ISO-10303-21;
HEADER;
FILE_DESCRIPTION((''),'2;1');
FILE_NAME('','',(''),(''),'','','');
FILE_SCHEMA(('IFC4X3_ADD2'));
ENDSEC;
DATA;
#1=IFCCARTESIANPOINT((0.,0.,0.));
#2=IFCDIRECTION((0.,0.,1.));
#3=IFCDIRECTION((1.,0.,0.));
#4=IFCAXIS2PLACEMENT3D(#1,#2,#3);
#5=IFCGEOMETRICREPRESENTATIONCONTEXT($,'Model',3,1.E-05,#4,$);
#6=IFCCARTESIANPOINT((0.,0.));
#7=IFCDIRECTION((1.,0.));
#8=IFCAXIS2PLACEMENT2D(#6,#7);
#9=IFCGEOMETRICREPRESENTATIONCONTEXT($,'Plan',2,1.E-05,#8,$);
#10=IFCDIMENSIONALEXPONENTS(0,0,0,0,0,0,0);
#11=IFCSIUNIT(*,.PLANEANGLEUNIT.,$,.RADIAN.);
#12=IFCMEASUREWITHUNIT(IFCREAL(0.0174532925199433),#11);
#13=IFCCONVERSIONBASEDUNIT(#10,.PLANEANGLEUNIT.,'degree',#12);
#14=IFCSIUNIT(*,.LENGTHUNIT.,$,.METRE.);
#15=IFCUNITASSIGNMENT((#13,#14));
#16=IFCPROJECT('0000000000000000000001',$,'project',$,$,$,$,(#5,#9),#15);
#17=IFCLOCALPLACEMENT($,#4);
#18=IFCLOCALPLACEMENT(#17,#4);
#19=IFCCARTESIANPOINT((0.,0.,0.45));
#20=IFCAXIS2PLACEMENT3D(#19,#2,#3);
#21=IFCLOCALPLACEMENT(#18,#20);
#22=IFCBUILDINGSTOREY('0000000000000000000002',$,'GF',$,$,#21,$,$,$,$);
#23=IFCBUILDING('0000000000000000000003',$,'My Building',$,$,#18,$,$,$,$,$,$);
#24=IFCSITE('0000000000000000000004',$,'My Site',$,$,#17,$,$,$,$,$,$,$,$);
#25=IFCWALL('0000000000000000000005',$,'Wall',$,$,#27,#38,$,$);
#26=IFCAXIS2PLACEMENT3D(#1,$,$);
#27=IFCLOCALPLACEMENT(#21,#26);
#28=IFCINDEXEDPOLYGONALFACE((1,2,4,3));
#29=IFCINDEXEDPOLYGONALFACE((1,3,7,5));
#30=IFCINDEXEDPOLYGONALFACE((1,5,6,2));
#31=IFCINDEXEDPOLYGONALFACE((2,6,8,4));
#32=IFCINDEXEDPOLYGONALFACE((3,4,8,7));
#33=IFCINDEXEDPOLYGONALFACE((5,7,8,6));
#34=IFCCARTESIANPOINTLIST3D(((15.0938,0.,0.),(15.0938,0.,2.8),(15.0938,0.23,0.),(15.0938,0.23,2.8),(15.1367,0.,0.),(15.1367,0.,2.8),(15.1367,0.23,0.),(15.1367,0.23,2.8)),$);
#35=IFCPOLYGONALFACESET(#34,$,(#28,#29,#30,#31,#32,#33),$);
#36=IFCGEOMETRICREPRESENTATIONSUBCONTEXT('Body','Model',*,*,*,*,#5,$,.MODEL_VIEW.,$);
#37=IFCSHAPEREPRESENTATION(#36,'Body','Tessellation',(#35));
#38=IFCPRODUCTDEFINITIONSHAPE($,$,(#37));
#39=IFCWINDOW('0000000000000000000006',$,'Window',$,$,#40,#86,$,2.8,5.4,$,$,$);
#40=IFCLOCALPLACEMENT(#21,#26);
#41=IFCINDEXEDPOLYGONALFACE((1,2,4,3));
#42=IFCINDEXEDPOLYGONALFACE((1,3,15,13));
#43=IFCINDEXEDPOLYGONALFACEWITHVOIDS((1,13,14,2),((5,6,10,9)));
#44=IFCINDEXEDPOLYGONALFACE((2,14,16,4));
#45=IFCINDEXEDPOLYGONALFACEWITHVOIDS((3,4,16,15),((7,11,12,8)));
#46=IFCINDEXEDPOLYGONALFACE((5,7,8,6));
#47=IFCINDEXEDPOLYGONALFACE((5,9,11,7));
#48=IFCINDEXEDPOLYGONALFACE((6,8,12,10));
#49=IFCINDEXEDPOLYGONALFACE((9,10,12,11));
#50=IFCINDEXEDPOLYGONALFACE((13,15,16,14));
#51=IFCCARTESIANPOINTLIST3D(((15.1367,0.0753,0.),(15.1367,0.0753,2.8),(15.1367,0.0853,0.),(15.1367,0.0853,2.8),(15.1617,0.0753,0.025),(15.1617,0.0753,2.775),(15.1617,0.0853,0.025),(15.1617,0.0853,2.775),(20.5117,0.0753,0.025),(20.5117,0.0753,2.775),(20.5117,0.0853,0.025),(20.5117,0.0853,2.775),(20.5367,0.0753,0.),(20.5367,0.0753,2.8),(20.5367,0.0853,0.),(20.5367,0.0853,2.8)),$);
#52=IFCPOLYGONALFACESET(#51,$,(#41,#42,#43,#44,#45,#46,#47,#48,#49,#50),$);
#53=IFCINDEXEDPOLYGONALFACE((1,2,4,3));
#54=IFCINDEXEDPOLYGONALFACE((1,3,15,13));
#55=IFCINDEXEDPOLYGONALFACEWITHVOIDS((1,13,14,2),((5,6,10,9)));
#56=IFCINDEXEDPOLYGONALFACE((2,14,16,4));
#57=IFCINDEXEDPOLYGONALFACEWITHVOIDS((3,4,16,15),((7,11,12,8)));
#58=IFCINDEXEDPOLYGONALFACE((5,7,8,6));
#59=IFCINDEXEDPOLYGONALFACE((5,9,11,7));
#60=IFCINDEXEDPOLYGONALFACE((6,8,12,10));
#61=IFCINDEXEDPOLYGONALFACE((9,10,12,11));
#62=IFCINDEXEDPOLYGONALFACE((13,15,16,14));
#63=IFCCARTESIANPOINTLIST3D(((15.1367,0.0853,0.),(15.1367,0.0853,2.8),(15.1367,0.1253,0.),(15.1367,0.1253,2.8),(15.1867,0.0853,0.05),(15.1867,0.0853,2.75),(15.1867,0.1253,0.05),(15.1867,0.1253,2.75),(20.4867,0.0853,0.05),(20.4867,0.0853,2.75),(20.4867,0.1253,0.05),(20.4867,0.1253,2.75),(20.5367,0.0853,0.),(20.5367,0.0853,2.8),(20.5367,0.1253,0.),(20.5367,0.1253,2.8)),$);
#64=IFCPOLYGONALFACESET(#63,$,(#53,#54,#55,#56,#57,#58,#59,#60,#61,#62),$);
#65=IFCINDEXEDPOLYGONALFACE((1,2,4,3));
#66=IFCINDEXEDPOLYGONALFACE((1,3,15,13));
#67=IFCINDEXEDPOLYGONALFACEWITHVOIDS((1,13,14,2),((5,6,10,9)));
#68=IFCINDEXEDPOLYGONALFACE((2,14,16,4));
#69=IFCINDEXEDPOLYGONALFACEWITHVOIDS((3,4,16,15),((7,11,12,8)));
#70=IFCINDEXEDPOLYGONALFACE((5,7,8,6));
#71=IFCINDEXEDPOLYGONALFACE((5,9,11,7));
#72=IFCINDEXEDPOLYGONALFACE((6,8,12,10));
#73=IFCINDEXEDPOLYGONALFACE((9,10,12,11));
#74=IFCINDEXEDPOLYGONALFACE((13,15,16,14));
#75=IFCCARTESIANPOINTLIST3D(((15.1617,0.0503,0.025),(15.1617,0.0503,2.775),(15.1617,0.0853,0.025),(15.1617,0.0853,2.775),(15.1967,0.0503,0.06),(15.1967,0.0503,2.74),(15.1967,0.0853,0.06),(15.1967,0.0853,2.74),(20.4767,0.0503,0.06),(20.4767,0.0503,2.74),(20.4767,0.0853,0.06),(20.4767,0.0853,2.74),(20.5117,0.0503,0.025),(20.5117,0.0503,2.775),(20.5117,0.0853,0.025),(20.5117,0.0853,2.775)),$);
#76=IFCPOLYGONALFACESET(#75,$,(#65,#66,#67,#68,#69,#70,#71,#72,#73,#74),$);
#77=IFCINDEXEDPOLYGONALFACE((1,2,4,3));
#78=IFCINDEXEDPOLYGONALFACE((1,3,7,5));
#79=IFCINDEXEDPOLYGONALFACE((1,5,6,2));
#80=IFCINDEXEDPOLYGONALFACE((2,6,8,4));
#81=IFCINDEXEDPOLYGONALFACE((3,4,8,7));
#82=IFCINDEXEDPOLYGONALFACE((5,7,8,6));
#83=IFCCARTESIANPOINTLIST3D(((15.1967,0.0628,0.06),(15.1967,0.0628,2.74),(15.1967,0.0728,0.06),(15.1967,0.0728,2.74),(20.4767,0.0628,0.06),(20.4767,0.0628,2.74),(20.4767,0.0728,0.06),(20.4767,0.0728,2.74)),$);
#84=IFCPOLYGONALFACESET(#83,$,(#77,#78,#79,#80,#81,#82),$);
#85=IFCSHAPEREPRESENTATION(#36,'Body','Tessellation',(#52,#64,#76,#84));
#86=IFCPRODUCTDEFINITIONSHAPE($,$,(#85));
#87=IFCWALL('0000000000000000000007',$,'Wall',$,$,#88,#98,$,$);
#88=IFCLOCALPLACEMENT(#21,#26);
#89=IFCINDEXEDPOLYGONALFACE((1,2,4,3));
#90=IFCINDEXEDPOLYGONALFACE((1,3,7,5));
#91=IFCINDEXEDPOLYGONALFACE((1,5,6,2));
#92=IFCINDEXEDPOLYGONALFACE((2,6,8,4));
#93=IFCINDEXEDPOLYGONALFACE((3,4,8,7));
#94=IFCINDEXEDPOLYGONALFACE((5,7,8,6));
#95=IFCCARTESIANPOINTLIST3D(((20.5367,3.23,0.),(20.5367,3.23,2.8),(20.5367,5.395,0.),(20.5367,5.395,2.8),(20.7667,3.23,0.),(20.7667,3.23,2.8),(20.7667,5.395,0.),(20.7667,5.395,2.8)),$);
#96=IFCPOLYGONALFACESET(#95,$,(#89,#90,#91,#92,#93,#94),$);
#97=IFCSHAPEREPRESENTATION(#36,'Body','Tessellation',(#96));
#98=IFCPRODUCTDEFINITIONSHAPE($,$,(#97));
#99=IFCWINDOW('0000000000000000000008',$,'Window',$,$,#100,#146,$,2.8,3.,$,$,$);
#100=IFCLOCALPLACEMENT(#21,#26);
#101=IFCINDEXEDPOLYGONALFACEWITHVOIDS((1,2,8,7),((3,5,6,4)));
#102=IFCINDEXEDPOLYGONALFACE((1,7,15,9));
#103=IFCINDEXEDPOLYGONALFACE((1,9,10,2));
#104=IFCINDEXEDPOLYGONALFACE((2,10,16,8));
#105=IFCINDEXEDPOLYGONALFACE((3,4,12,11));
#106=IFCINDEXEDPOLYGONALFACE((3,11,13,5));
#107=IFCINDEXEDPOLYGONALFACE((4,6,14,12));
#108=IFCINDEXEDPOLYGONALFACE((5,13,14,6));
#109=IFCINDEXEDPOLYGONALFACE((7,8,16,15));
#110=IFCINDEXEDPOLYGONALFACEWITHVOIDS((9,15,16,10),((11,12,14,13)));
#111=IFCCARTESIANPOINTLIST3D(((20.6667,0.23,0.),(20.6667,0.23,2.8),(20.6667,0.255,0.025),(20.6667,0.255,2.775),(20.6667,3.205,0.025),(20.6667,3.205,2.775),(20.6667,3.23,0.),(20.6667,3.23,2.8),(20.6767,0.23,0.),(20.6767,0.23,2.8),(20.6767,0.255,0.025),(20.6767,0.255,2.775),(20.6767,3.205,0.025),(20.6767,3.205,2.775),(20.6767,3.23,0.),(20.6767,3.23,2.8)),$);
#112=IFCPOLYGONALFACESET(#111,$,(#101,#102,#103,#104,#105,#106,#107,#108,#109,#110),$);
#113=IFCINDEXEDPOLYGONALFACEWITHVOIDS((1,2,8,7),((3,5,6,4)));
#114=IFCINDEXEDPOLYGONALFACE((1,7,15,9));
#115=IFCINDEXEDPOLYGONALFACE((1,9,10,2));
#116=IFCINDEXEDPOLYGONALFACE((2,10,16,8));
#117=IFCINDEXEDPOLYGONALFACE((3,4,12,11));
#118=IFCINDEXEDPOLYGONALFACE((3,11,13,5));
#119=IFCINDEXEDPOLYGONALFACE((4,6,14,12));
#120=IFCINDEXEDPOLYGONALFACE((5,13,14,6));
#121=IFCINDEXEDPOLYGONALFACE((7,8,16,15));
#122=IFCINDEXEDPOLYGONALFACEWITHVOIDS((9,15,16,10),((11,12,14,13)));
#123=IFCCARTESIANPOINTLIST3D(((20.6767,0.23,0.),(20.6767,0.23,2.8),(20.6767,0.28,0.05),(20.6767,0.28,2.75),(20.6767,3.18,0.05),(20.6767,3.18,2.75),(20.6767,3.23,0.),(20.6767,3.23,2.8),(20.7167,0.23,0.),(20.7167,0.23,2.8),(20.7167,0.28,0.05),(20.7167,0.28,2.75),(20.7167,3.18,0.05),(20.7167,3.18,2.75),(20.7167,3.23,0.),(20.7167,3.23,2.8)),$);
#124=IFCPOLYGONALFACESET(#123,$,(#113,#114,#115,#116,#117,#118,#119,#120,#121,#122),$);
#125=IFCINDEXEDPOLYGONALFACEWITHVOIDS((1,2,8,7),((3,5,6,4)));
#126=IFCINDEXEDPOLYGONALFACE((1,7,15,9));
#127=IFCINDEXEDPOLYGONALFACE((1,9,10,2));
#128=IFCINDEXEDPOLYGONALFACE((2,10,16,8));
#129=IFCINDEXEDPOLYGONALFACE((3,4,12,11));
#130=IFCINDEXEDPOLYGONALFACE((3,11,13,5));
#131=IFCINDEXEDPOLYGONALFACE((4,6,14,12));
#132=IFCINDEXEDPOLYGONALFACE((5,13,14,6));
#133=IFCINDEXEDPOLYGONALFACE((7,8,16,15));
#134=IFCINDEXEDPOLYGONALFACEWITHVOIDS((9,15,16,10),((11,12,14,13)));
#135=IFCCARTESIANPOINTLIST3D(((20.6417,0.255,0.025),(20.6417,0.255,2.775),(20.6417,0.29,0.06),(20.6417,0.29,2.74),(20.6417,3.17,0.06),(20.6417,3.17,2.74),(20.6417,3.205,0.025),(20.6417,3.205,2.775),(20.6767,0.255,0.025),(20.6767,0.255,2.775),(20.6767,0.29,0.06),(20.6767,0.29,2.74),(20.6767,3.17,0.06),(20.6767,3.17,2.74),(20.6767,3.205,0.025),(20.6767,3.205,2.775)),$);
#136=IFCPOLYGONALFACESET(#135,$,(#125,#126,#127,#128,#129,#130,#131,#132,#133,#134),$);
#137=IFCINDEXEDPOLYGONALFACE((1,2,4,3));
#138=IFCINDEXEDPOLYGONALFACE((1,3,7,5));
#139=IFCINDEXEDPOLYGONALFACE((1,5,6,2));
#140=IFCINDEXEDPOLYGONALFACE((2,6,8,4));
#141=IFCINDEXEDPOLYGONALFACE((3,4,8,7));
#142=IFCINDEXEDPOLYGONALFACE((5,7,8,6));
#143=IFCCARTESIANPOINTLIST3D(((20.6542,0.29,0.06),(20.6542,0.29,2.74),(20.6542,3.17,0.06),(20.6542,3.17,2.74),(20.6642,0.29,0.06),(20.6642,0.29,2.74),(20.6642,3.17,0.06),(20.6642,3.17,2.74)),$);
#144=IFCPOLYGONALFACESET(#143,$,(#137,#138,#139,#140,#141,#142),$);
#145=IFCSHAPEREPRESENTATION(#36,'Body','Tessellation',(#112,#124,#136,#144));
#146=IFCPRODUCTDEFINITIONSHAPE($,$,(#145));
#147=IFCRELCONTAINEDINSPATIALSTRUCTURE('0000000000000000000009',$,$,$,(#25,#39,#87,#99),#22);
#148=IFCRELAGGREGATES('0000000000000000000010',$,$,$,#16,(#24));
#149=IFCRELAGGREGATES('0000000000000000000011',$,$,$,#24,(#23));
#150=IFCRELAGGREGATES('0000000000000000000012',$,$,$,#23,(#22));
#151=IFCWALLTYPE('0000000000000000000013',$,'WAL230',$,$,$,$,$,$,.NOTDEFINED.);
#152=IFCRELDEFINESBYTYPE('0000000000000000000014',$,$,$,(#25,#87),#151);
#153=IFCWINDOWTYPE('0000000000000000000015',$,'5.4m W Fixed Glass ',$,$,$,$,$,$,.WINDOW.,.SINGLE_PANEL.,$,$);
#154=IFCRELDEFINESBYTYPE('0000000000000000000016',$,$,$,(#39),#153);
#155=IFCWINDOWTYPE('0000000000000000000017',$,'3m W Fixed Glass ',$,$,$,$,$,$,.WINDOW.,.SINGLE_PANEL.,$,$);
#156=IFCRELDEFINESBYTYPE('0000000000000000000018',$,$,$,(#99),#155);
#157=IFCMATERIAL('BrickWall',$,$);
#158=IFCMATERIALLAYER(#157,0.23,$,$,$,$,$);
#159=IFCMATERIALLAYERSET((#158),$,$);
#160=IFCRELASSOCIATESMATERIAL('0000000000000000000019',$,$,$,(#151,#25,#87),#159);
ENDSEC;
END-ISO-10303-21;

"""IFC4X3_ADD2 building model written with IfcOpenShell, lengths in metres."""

from ifc_helpers import new_model, entity, si_unit, converted_unit, frame, origin_with_axes, origin_2d_with_axis, place, context, subcontext, project, spatial, line, indexed_curve, outline, extrude, shape, source, transform, mapped, material, layer, layer_set, layer_usage, type_object, type_shapes, element, fill, save


model = new_model("IFC4X3_ADD2")

# Units and contexts
model_context = context("Model", 3, precision=1e-05, world=origin_with_axes())
plan_context = context("Plan", 2, precision=1e-05, world=origin_2d_with_axis())
body_context_1 = subcontext(model_context, "Body", "Model", "MODEL_VIEW")
body_context_2 = subcontext(plan_context, "Body", "Plan", "PLAN_VIEW")
ifc_project = project(units=[converted_unit("PLANEANGLEUNIT", "degree", entity("IfcReal", 0.0174532925199433), si_unit("PLANEANGLEUNIT", "RADIAN"), dimensions=[0, 0, 0, 0, 0, 0, 0]), si_unit("LENGTHUNIT", "METRE")], contexts=[model_context, plan_context])

# Site, building, storey
site_placement = place(None, origin_with_axes())
site = spatial("IfcSite", under=ifc_project, at=site_placement, Name="My Site")
building_placement = place(site_placement, origin_with_axes())
building = spatial("IfcBuilding", under=site, at=building_placement, Name="My Building")
storey_placement = place(building_placement, frame((0.0, 0.0, 0.45), z_axis=(0.0, 0.0, 1.0), x_axis=(1.0, 0.0, 0.0)))
storey = spatial("IfcBuildingStorey", under=building, at=storey_placement, Name="GF")

# Walls, openings, windows
ifc_material = material(Name="BrickWall")
ifc_layer_1 = layer(ifc_material, 0.23)
ifc_layer_set_1 = layer_set([ifc_layer_1])
ifc_layer_usage_1 = layer_usage(ifc_layer_set_1, "AXIS2", "POSITIVE", 0.0)
wall_type_1 = type_object("IfcWallType", Name="WAL230", PredefinedType="NOTDEFINED", material=ifc_layer_set_1)
wall_1_placement = place(storey_placement, frame((15.1367, 0.23, 0.0), z_axis=(0.0, 0.0, 1.0), x_axis=(-1.0, 0.0, 0.0)))
wall_1 = element("IfcWall", 1, at=wall_1_placement, inside=storey, type_object=wall_type_1, material=ifc_layer_usage_1, Name="Wall", context=body_context_1, shape_type="SweptSolid", body=[
    extrude(outline(indexed_curve([(0.0, 0.0), (0.0, 0.23), (0.0429, 0.23), (0.0429, 0.0), (0.0, 0.0)], self_intersect=False)), origin_with_axes(), (0.0, 0.0, 1.0), 2.8),
])
shared_shape_1 = source(origin_with_axes(), body_context_1, "Body", "SweptSolid", [
    extrude(outline(indexed_curve([(0.0, 0.0), (5.4, 0.0), (5.4, 2.8), (0.0, 2.8)], segments=[line(1, 2, 3, 4, 1)])), frame((0.0, -0.6, 0.0), z_axis=(0.0, -1.0, 0.0), x_axis=(1.0, 0.0, 0.0)), (0.0, 0.0, -1.0), 1.2),
])
opening_1_placement = place(wall_1_placement, frame((-5.4, 0.0, 0.0), z_axis=(0.0, 0.0, 1.0), x_axis=(1.0, 0.0, 0.0)))
opening_1 = element("IfcOpeningElement", 2, at=opening_1_placement, cuts=wall_1, PredefinedType="OPENING", context=body_context_1, shape_type="MappedRepresentation", body=[
    mapped(shared_shape_1, transform((0.0, 0.0, 0.0), x_axis=(1.0, 0.0, 0.0), y_axis=(0.0, 1.0, 0.0), z_axis=(0.0, 0.0, 1.0), scale=1.0)),
])
window_type_1 = type_object("IfcWindowType", Name="5.4m W Fixed Glass ", PartitioningType="SINGLE_PANEL", PredefinedType="WINDOW")
shared_shape_2 = source(origin_with_axes(), body_context_1, "Body", "SweptSolid", [
    extrude(outline(indexed_curve([(0.0, 0.0), (5.4, 0.0), (5.4, 2.8), (0.0, 2.8)], segments=[line(1, 2, 3, 4, 1)]), holes=[indexed_curve([(0.025, 0.025), (5.375, 0.025), (5.375, 2.775), (0.025, 2.775)], segments=[line(1, 2, 3, 4, 1)])]), frame((0.0, 0.09, 0.0), z_axis=(0.0, -1.0, 0.0), x_axis=(1.0, 0.0, 0.0)), (0.0, 0.0, -1.0), 0.01),
    extrude(outline(indexed_curve([(0.0, 0.0), (5.4, 0.0), (5.4, 2.8), (0.0, 2.8)], segments=[line(1, 2, 3, 4, 1)]), holes=[indexed_curve([(0.05, 0.05), (5.35, 0.05), (5.35, 2.75), (0.05, 2.75)], segments=[line(1, 2, 3, 4, 1)])]), frame((0.0, 0.05, 0.0), z_axis=(0.0, -1.0, 0.0), x_axis=(1.0, 0.0, 0.0)), (0.0, 0.0, -1.0), 0.04),
    extrude(outline(indexed_curve([(0.0, 0.0), (5.35, 0.0), (5.35, 2.75), (0.0, 2.75)], segments=[line(1, 2, 3, 4, 1)]), holes=[indexed_curve([(0.035, 0.035), (5.315, 0.035), (5.315, 2.715), (0.035, 2.715)], segments=[line(1, 2, 3, 4, 1)])]), frame((0.025, 0.09, 0.025), z_axis=(0.0, -1.0, 0.0), x_axis=(1.0, 0.0, 0.0)), (0.0, 0.0, -1.0), 0.035),
    extrude(outline(indexed_curve([(0.035, 0.035), (5.315, 0.035), (5.315, 2.715), (0.035, 2.715)], segments=[line(1, 2, 3, 4, 1)])), frame((0.025, 0.1025, 0.025), z_axis=(0.0, -1.0, 0.0), x_axis=(1.0, 0.0, 0.0)), (0.0, 0.0, -1.0), 0.01),
])
shared_shape_3 = source(origin_with_axes(), body_context_2, "Body", "Curve2D", [
    entity("IfcIndexedPolyCurve", entity("IfcCartesianPointList2D", [[0.05, 0.05], [5.35, 0.05]])),
    entity("IfcIndexedPolyCurve", entity("IfcCartesianPointList2D", [[0.0, 0.1], [0.025, 0.1], [0.025, 0.09], [0.05, 0.09], [0.05, 0.05], [0.0, 0.05]]), [entity("IfcLineIndex", [1, 2, 3, 4, 5, 6, 1])]),
    entity("IfcIndexedPolyCurve", entity("IfcCartesianPointList2D", [[5.4, 0.1], [5.375, 0.1], [5.375, 0.09], [5.35, 0.09], [5.35, 0.05], [5.4, 0.05]]), [entity("IfcLineIndex", [1, 2, 3, 4, 5, 6, 1])]),
    entity("IfcIndexedPolyCurve", entity("IfcCartesianPointList2D", [[0.025, 0.09], [0.06, 0.09], [0.06, 0.125], [0.025, 0.125]]), [entity("IfcLineIndex", [1, 2, 3, 4, 1])]),
    entity("IfcIndexedPolyCurve", entity("IfcCartesianPointList2D", [[5.375, 0.09], [5.34, 0.09], [5.34, 0.125], [5.375, 0.125]]), [entity("IfcLineIndex", [1, 2, 3, 4, 1])]),
    entity("IfcIndexedPolyCurve", entity("IfcCartesianPointList2D", [[0.06, 0.09], [5.34, 0.09]])),
    entity("IfcIndexedPolyCurve", entity("IfcCartesianPointList2D", [[0.06, 0.125], [5.34, 0.125]])),
    entity("IfcIndexedPolyCurve", entity("IfcCartesianPointList2D", [[0.06, 0.1075], [5.34, 0.1075]])),
])
type_shapes(window_type_1, [shared_shape_2, shared_shape_3])
window_1_placement = place(opening_1_placement, frame((0.0, 0.0547, 0.0), z_axis=(0.0, 0.0, 1.0), x_axis=(1.0, 0.0, 0.0)))
window_1 = element("IfcWindow", 3, at=window_1_placement, inside=storey, type_object=window_type_1, Name="Window", OverallHeight=2.8, OverallWidth=5.4, shapes=[
    shape(body_context_1, "Body", "MappedRepresentation", [mapped(shared_shape_2, transform((0.0, 0.0, 0.0), x_axis=(1.0, 0.0, 0.0), y_axis=(0.0, 1.0, 0.0), z_axis=(0.0, 0.0, 1.0), scale=1.0))]),
    shape(body_context_2, "Body", "MappedRepresentation", [mapped(shared_shape_3, transform((0.0, 0.0, 0.0), x_axis=(1.0, 0.0, 0.0), y_axis=(0.0, 1.0, 0.0), z_axis=(0.0, 0.0, 1.0), scale=1.0))]),
])
fill(opening_1, window_1)
ifc_layer_usage_2 = layer_usage(ifc_layer_set_1, "AXIS2", "POSITIVE", 0.0)
wall_2_placement = place(storey_placement, frame((20.7667, 0.23, 0.0), z_axis=(0.0, 0.0, 1.0), x_axis=(0.0, 1.0, 0.0)))
wall_2 = element("IfcWall", 4, at=wall_2_placement, inside=storey, type_object=wall_type_1, material=ifc_layer_usage_2, Name="Wall", context=body_context_1, shape_type="SweptSolid", body=[
    extrude(outline(indexed_curve([(0.0, 0.0), (0.0, 0.23), (5.165, 0.23), (5.165, 0.0), (0.0, 0.0)], self_intersect=False)), origin_with_axes(), (0.0, 0.0, 1.0), 2.8),
])
shared_shape_4 = source(origin_with_axes(), body_context_1, "Body", "SweptSolid", [
    extrude(outline(indexed_curve([(0.0, 0.0), (3.0, 0.0), (3.0, 2.8), (0.0, 2.8)], segments=[line(1, 2, 3, 4, 1)])), frame((0.0, -0.6, 0.0), z_axis=(0.0, -1.0, 0.0), x_axis=(1.0, 0.0, 0.0)), (0.0, 0.0, -1.0), 1.2),
])
opening_2_placement = place(wall_2_placement, frame((0.0, 0.0, 0.0), z_axis=(0.0, 0.0, 1.0), x_axis=(1.0, 0.0, 0.0)))
opening_2 = element("IfcOpeningElement", 5, at=opening_2_placement, cuts=wall_2, PredefinedType="OPENING", context=body_context_1, shape_type="MappedRepresentation", body=[
    mapped(shared_shape_4, transform((0.0, 0.0, 0.0), x_axis=(1.0, 0.0, 0.0), y_axis=(0.0, 1.0, 0.0), z_axis=(0.0, 0.0, 1.0), scale=1.0)),
])
window_type_2 = type_object("IfcWindowType", Name="3m W Fixed Glass ", PartitioningType="SINGLE_PANEL", PredefinedType="WINDOW")
shared_shape_5 = source(origin_with_axes(), body_context_1, "Body", "SweptSolid", [
    extrude(outline(indexed_curve([(0.0, 0.0), (3.0, 0.0), (3.0, 2.8), (0.0, 2.8)], segments=[line(1, 2, 3, 4, 1)]), holes=[indexed_curve([(0.025, 0.025), (2.975, 0.025), (2.975, 2.775), (0.025, 2.775)], segments=[line(1, 2, 3, 4, 1)])]), frame((0.0, 0.09, 0.0), z_axis=(0.0, -1.0, 0.0), x_axis=(1.0, 0.0, 0.0)), (0.0, 0.0, -1.0), 0.01),
    extrude(outline(indexed_curve([(0.0, 0.0), (3.0, 0.0), (3.0, 2.8), (0.0, 2.8)], segments=[line(1, 2, 3, 4, 1)]), holes=[indexed_curve([(0.05, 0.05), (2.95, 0.05), (2.95, 2.75), (0.05, 2.75)], segments=[line(1, 2, 3, 4, 1)])]), frame((0.0, 0.05, 0.0), z_axis=(0.0, -1.0, 0.0), x_axis=(1.0, 0.0, 0.0)), (0.0, 0.0, -1.0), 0.04),
    extrude(outline(indexed_curve([(0.0, 0.0), (2.95, 0.0), (2.95, 2.75), (0.0, 2.75)], segments=[line(1, 2, 3, 4, 1)]), holes=[indexed_curve([(0.035, 0.035), (2.915, 0.035), (2.915, 2.715), (0.035, 2.715)], segments=[line(1, 2, 3, 4, 1)])]), frame((0.025, 0.09, 0.025), z_axis=(0.0, -1.0, 0.0), x_axis=(1.0, 0.0, 0.0)), (0.0, 0.0, -1.0), 0.035),
    extrude(outline(indexed_curve([(0.035, 0.035), (2.915, 0.035), (2.915, 2.715), (0.035, 2.715)], segments=[line(1, 2, 3, 4, 1)])), frame((0.025, 0.1025, 0.025), z_axis=(0.0, -1.0, 0.0), x_axis=(1.0, 0.0, 0.0)), (0.0, 0.0, -1.0), 0.01),
])
shared_shape_6 = source(origin_with_axes(), body_context_2, "Body", "Curve2D", [
    entity("IfcIndexedPolyCurve", entity("IfcCartesianPointList2D", [[0.05, 0.05], [2.95, 0.05]])),
    entity("IfcIndexedPolyCurve", entity("IfcCartesianPointList2D", [[0.0, 0.1], [0.025, 0.1], [0.025, 0.09], [0.05, 0.09], [0.05, 0.05], [0.0, 0.05]]), [entity("IfcLineIndex", [1, 2, 3, 4, 5, 6, 1])]),
    entity("IfcIndexedPolyCurve", entity("IfcCartesianPointList2D", [[3.0, 0.1], [2.975, 0.1], [2.975, 0.09], [2.95, 0.09], [2.95, 0.05], [3.0, 0.05]]), [entity("IfcLineIndex", [1, 2, 3, 4, 5, 6, 1])]),
    entity("IfcIndexedPolyCurve", entity("IfcCartesianPointList2D", [[0.025, 0.09], [0.06, 0.09], [0.06, 0.125], [0.025, 0.125]]), [entity("IfcLineIndex", [1, 2, 3, 4, 1])]),
    entity("IfcIndexedPolyCurve", entity("IfcCartesianPointList2D", [[2.975, 0.09], [2.94, 0.09], [2.94, 0.125], [2.975, 0.125]]), [entity("IfcLineIndex", [1, 2, 3, 4, 1])]),
    entity("IfcIndexedPolyCurve", entity("IfcCartesianPointList2D", [[0.06, 0.09], [2.94, 0.09]])),
    entity("IfcIndexedPolyCurve", entity("IfcCartesianPointList2D", [[0.06, 0.125], [2.94, 0.125]])),
    entity("IfcIndexedPolyCurve", entity("IfcCartesianPointList2D", [[0.06, 0.1075], [2.94, 0.1075]])),
])
type_shapes(window_type_2, [shared_shape_5, shared_shape_6])
window_2_placement = place(opening_2_placement, frame((0.0, 0.0, 0.0), z_axis=(0.0, 0.0, 1.0), x_axis=(1.0, 0.0, 0.0)))
window_2 = element("IfcWindow", 6, at=window_2_placement, inside=storey, type_object=window_type_2, Name="Window", OverallHeight=2.8, OverallWidth=3.0, shapes=[
    shape(body_context_1, "Body", "MappedRepresentation", [mapped(shared_shape_5, transform((0.0, 0.0, 0.0), x_axis=(1.0, 0.0, 0.0), y_axis=(0.0, 1.0, 0.0), z_axis=(0.0, 0.0, 1.0), scale=1.0))]),
    shape(body_context_2, "Body", "MappedRepresentation", [mapped(shared_shape_6, transform((0.0, 0.0, 0.0), x_axis=(1.0, 0.0, 0.0), y_axis=(0.0, 1.0, 0.0), z_axis=(0.0, 0.0, 1.0), scale=1.0))]),
])
fill(opening_2, window_2)

save(model, "model.ifc")
